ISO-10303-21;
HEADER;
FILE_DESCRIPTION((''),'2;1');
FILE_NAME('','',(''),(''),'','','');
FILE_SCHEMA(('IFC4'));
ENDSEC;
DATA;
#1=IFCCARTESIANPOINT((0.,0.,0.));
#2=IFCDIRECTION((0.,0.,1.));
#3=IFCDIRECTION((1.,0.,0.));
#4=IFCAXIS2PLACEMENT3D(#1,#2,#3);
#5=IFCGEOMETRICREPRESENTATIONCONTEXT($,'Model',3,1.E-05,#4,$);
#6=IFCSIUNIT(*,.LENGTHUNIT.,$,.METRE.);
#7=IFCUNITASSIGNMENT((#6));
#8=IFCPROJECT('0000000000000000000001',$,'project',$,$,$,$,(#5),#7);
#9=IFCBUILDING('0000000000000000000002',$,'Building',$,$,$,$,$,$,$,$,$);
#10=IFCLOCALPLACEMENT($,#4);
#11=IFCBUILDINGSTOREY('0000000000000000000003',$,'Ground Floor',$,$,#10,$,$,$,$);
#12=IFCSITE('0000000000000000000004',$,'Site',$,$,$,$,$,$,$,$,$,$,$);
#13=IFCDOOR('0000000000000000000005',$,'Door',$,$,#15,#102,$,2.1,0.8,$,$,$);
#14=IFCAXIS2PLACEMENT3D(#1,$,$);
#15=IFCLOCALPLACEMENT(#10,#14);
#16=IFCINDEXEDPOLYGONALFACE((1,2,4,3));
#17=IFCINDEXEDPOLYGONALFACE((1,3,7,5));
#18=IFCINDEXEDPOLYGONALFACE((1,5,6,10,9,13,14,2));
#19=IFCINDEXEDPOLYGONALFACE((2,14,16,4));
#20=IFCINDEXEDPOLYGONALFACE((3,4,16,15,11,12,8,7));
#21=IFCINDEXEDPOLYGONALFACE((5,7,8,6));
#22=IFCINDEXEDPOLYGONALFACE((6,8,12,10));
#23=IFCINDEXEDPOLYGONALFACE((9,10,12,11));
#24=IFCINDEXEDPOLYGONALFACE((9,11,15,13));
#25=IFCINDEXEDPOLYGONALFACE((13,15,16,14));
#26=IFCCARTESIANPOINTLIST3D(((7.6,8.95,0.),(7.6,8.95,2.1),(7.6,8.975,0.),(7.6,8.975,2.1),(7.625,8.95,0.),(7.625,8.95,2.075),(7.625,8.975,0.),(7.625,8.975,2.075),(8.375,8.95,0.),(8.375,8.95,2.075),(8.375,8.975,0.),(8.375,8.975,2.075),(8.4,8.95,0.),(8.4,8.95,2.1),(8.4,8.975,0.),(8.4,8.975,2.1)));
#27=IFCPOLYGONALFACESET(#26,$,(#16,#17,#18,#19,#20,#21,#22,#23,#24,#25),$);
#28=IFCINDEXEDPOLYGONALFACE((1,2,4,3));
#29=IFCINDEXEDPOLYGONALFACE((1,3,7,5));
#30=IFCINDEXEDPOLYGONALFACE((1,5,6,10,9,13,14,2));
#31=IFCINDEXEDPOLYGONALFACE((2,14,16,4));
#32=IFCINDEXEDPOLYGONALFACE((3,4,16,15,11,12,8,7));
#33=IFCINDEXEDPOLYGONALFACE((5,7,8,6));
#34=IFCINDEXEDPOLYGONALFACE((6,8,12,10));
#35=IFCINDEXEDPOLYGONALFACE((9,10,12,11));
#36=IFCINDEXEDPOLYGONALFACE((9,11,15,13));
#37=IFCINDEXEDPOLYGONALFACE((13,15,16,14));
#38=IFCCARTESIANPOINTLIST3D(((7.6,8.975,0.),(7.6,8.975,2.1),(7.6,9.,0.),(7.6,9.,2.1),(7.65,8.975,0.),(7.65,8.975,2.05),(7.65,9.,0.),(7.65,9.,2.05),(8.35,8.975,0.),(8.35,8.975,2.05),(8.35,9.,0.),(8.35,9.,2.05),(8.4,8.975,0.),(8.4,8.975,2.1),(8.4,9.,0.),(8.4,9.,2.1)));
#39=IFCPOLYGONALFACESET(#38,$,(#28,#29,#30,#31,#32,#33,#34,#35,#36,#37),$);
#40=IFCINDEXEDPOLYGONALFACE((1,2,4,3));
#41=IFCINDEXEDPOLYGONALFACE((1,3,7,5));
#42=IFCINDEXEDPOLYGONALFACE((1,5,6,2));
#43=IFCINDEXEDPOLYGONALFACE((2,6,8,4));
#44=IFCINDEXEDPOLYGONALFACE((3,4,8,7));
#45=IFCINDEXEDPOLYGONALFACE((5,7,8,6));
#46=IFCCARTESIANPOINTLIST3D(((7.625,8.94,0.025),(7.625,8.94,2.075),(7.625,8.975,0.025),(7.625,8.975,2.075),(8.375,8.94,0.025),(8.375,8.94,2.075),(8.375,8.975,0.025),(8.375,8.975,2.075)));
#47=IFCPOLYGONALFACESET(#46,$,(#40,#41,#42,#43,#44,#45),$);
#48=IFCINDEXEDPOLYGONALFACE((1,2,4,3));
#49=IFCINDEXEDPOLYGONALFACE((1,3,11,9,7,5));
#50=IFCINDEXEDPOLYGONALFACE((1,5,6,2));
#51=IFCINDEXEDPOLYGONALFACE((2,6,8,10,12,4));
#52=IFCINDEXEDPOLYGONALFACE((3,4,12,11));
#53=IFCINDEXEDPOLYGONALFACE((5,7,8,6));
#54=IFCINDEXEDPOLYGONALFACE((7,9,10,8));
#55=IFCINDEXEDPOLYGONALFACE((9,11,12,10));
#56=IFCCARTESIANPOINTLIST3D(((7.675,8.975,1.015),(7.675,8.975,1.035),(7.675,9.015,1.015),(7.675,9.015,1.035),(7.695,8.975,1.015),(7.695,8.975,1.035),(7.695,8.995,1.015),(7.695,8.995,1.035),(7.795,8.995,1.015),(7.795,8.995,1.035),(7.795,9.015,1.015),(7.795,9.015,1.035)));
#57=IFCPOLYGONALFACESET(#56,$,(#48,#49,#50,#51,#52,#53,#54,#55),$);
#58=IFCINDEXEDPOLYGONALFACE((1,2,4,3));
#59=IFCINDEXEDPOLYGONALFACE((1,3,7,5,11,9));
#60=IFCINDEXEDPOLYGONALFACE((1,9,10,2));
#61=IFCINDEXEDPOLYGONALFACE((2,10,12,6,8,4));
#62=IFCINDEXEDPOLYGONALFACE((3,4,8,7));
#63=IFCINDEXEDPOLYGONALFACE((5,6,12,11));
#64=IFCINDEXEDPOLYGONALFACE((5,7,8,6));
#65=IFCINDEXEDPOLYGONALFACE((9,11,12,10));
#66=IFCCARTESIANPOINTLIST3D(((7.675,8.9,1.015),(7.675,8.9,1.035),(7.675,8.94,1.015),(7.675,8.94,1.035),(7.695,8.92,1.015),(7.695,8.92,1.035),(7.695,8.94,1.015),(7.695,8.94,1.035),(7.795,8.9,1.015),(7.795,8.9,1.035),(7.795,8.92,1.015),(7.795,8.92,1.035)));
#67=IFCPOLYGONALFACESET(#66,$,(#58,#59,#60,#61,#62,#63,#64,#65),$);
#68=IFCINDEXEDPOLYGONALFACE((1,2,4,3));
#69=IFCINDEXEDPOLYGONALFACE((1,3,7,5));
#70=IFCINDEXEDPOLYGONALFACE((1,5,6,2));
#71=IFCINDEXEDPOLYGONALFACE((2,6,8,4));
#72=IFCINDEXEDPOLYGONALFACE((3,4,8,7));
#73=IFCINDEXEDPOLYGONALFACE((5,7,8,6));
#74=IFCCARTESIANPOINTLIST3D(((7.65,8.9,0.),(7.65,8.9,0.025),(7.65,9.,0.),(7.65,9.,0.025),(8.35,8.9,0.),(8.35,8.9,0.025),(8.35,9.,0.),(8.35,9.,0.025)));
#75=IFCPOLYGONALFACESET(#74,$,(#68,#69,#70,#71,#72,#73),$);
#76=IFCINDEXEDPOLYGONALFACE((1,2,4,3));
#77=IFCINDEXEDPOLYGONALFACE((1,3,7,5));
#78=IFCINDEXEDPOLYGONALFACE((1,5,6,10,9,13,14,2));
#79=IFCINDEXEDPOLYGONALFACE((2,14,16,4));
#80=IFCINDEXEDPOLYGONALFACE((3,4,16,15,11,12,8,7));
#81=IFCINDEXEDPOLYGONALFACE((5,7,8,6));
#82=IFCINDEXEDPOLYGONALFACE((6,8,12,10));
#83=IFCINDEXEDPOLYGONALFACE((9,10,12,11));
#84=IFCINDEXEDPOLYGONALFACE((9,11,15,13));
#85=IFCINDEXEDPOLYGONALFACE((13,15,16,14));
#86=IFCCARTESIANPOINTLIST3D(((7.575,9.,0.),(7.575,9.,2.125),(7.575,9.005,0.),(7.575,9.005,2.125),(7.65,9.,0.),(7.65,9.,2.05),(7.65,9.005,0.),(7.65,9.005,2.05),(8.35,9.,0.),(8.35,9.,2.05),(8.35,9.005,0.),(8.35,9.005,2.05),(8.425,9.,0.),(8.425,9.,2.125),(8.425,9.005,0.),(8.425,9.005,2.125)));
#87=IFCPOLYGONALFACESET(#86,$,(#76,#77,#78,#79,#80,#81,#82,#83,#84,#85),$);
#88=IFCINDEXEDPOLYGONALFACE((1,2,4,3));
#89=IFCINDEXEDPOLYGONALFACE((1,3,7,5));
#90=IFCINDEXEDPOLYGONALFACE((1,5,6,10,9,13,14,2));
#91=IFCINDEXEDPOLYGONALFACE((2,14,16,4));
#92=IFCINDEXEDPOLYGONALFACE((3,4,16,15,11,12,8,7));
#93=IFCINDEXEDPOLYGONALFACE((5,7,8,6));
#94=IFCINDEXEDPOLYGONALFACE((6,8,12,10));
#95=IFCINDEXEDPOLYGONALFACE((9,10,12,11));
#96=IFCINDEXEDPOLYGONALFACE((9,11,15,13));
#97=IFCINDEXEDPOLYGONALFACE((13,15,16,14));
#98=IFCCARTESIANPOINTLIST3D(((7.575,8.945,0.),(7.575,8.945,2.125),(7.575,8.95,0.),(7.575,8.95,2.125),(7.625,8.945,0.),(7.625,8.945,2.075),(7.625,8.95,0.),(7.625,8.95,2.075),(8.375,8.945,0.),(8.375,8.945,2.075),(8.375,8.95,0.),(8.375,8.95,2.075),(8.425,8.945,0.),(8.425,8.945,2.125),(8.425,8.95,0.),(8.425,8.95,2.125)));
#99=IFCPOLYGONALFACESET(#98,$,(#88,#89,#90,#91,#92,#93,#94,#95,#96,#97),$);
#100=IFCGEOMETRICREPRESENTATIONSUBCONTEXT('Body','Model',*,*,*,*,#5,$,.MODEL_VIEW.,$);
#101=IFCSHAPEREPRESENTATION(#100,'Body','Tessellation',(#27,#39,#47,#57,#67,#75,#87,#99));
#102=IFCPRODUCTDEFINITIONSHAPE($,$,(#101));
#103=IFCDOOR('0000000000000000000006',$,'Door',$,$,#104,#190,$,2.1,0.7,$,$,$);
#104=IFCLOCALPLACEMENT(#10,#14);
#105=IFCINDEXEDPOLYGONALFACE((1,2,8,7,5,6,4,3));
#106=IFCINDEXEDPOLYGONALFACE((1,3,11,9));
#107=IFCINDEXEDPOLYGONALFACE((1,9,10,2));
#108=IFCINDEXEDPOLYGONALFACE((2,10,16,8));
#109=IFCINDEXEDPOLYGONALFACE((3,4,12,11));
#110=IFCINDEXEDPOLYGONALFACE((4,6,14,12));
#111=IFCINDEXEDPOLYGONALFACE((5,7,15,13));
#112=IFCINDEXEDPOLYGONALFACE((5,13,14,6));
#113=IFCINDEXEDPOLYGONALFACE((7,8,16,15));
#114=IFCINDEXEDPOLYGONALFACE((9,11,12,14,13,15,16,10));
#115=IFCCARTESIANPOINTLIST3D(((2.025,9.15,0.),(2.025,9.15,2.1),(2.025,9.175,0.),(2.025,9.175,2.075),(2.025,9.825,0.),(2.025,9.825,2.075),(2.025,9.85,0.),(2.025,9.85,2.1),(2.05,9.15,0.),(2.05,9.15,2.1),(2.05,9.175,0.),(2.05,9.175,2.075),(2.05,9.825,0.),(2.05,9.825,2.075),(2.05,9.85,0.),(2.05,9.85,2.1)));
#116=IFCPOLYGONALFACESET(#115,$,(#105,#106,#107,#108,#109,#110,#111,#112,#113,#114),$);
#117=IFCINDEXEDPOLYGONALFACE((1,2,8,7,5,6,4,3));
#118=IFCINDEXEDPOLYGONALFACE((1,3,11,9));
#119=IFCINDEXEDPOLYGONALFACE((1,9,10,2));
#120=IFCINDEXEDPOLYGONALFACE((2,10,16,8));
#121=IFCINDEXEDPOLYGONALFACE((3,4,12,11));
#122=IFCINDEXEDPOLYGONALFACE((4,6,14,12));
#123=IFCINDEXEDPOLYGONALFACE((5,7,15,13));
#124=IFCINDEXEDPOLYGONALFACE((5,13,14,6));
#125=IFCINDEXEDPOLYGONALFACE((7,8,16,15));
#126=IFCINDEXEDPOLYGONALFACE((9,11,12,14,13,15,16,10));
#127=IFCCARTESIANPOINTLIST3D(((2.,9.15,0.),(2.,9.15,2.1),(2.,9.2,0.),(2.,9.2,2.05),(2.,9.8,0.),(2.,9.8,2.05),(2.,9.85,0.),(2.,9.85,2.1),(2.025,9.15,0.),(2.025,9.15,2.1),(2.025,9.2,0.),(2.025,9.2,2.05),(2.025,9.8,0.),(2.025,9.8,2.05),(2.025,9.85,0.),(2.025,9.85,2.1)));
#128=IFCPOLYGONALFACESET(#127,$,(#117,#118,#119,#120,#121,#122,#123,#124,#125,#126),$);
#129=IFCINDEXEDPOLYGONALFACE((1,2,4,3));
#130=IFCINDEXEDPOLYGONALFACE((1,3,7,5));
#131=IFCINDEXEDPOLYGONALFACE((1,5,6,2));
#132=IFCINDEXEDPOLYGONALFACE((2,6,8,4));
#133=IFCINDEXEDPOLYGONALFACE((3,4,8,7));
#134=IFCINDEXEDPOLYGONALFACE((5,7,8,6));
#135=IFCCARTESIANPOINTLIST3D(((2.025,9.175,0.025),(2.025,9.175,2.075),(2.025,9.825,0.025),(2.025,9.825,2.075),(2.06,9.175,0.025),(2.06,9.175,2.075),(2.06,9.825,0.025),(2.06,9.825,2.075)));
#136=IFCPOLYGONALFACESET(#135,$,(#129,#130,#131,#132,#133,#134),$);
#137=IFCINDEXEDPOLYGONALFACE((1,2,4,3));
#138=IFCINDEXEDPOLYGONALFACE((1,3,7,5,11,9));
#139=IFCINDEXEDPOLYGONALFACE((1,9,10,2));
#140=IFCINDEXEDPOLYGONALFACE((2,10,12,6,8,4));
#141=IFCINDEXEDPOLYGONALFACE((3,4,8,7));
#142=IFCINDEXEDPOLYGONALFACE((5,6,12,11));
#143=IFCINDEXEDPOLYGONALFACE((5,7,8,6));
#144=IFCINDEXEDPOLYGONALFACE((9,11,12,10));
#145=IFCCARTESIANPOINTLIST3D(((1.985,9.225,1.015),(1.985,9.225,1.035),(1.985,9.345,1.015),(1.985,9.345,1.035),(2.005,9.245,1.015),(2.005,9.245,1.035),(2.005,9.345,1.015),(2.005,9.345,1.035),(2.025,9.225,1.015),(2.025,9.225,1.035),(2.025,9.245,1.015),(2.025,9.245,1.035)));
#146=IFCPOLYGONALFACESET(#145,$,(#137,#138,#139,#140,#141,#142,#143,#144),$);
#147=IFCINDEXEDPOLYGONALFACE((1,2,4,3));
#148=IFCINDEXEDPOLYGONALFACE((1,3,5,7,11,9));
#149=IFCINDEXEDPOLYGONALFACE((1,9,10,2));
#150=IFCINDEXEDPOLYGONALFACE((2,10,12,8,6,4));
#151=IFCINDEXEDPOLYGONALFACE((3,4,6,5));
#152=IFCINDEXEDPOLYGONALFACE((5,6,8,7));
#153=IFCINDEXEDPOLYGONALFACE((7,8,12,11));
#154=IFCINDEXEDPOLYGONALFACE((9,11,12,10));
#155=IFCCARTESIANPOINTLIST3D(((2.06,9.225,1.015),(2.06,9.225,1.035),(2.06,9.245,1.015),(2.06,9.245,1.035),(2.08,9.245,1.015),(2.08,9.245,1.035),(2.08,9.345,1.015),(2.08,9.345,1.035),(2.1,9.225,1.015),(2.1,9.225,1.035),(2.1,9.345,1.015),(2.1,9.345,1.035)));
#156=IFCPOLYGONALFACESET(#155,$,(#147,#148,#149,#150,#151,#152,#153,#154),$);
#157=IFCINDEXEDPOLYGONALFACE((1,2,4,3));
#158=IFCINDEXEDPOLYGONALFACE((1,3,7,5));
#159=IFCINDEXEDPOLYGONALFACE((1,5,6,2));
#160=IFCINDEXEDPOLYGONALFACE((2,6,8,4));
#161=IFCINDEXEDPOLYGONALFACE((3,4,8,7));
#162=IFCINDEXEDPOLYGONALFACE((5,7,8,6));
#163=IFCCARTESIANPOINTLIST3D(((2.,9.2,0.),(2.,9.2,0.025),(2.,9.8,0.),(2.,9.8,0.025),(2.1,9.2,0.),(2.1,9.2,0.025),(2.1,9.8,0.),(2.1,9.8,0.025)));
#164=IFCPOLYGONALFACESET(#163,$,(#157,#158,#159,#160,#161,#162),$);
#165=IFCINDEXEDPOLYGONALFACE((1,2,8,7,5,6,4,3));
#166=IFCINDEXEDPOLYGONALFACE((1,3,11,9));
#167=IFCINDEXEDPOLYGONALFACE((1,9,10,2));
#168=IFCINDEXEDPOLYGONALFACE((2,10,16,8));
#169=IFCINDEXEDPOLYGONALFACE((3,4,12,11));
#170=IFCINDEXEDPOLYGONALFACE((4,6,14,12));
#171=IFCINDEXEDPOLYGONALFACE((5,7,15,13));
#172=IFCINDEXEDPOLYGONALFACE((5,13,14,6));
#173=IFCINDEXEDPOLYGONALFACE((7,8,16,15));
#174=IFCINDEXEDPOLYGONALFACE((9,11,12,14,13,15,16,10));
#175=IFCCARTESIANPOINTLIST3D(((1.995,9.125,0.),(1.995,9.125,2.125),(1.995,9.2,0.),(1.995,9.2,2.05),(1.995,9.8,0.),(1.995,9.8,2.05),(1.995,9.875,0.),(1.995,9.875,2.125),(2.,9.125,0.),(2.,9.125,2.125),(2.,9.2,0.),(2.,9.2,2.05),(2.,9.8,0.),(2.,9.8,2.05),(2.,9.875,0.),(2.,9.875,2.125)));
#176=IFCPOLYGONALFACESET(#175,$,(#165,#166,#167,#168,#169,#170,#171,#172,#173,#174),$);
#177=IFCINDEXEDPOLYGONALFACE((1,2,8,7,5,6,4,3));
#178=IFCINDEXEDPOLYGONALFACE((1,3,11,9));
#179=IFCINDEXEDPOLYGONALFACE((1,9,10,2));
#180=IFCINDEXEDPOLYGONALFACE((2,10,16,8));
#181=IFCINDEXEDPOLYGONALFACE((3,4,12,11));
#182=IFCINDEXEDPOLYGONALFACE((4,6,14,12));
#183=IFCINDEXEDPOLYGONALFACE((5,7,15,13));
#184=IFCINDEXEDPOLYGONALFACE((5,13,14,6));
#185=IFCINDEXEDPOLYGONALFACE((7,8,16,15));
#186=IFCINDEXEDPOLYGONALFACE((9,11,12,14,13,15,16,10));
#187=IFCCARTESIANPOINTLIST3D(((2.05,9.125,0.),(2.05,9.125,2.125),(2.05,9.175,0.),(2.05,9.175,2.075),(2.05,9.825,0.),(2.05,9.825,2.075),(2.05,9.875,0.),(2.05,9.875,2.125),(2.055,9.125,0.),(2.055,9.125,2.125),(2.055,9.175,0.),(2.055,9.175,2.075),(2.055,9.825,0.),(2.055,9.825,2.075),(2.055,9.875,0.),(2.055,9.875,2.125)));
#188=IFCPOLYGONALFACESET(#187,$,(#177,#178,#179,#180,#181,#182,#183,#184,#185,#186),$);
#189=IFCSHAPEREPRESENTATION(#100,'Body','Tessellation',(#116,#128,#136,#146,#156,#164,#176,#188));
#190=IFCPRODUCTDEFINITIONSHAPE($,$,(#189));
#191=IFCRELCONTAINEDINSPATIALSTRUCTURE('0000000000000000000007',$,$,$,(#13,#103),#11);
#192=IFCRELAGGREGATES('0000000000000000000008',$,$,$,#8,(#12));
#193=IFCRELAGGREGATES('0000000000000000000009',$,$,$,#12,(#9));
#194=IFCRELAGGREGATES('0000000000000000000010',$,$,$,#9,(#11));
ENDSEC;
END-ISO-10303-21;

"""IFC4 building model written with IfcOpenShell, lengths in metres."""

from ifc_helpers import new_model, si_unit, frame, origin_with_axes, place, context, subcontext, project, spatial, line, indexed_curve, outline, extrude, element, save


model = new_model("IFC4")

# Units and contexts
model_context = context("Model", 3, precision=1e-05, world=origin_with_axes())
body_context = subcontext(model_context, "Body", "Model", "MODEL_VIEW")
ifc_project = project(units=[si_unit("LENGTHUNIT", "METRE")], contexts=[model_context])

# Site, building, storey
site = spatial("IfcSite", under=ifc_project, Name="Site")
building = spatial("IfcBuilding", under=site, Name="Building")
storey_placement = place(None, origin_with_axes())
storey = spatial("IfcBuildingStorey", under=building, at=storey_placement, Name="Ground Floor")

# Doors
door_1_placement = place(storey_placement, frame((8.4, 9.0, 0.0), z_axis=(0.0, 0.0, 1.0), x_axis=(-1.0, 0.0, 0.0)))
element("IfcDoor", 1, at=door_1_placement, inside=storey, Name="Door", OverallHeight=2.1, OverallWidth=0.8, context=body_context, shape_type="SweptSolid", body=[
    extrude(outline(indexed_curve([(0.0, 0.0), (0.0, 2.1), (0.8, 2.1), (0.8, 0.0), (0.775, 0.0), (0.775, 2.075), (0.025, 2.075), (0.025, 0.0)], segments=[line(1, 2, 3, 4, 5, 6, 7, 8, 1)])), frame((0.0, 0.025, 0.0), z_axis=(0.0, -1.0, 0.0), x_axis=(1.0, 0.0, 0.0)), (0.0, 0.0, -1.0), 0.025),
    extrude(outline(indexed_curve([(0.0, 0.0), (0.0, 2.1), (0.8, 2.1), (0.8, 0.0), (0.75, 0.0), (0.75, 2.05), (0.05, 2.05), (0.05, 0.0)], segments=[line(1, 2, 3, 4, 5, 6, 7, 8, 1)])), frame((0.0, 0.0, 0.0), z_axis=(0.0, -1.0, 0.0), x_axis=(1.0, 0.0, 0.0)), (0.0, 0.0, -1.0), 0.025),
    extrude(outline(indexed_curve([(0.0, 0.0), (0.75, 0.0), (0.75, 0.035), (0.0, 0.035)], segments=[line(1, 2, 3, 4, 1)])), frame((0.025, 0.025, 0.025), z_axis=(0.0, 0.0, 1.0), x_axis=(1.0, 0.0, 0.0)), (0.0, 0.0, 1.0), 2.05),
    extrude(outline(indexed_curve([(0.0, 0.0), (0.0, -0.04), (-0.12, -0.04), (-0.12, -0.02), (-0.02, -0.02), (-0.02, 0.0)], segments=[line(1, 2, 3, 4, 5, 6, 1)])), frame((0.725, 0.025, 1.015), z_axis=(0.0, 0.0, 1.0), x_axis=(1.0, 0.0, 0.0)), (0.0, 0.0, 1.0), 0.02),
    extrude(outline(indexed_curve([(0.0, 0.0), (0.0, 0.04), (-0.12, 0.04), (-0.12, 0.02), (-0.02, 0.02), (-0.02, 0.0)], segments=[line(1, 2, 3, 4, 5, 6, 1)])), frame((0.725, 0.06, 1.015), z_axis=(0.0, 0.0, 1.0), x_axis=(1.0, 0.0, 0.0)), (0.0, 0.0, 1.0), 0.02),
    extrude(outline(indexed_curve([(0.0, 0.0), (0.7, 0.0), (0.7, 0.1), (0.0, 0.1)], segments=[line(1, 2, 3, 4, 1)])), frame((0.05, 0.0, 0.0), z_axis=(0.0, 0.0, 1.0), x_axis=(1.0, 0.0, 0.0)), (0.0, 0.0, 1.0), 0.025),
    extrude(outline(indexed_curve([(0.0, 0.0), (0.0, 2.125), (0.85, 2.125), (0.85, 0.0), (0.775, 0.0), (0.775, 2.05), (0.075, 2.05), (0.075, 0.0)], segments=[line(1, 2, 3, 4, 5, 6, 7, 8, 1)])), frame((-0.025, -0.005, 0.0), z_axis=(0.0, -1.0, 0.0), x_axis=(1.0, 0.0, 0.0)), (0.0, 0.0, -1.0), 0.005),
    extrude(outline(indexed_curve([(0.0, 0.0), (0.0, 2.125), (0.85, 2.125), (0.85, 0.0), (0.8, 0.0), (0.8, 2.075), (0.05, 2.075), (0.05, 0.0)], segments=[line(1, 2, 3, 4, 5, 6, 7, 8, 1)])), frame((-0.025, 0.05, 0.0), z_axis=(0.0, -1.0, 0.0), x_axis=(1.0, 0.0, 0.0)), (0.0, 0.0, -1.0), 0.005),
])
door_2_placement = place(storey_placement, frame((2.0, 9.85, 0.0), z_axis=(0.0, 0.0, 1.0), x_axis=(0.0, -1.0, 0.0)))
element("IfcDoor", 2, at=door_2_placement, inside=storey, Name="Door", OverallHeight=2.1, OverallWidth=0.7, context=body_context, shape_type="SweptSolid", body=[
    extrude(outline(indexed_curve([(0.0, 0.0), (0.0, 2.1), (0.7, 2.1), (0.7, 0.0), (0.675, 0.0), (0.675, 2.075), (0.025, 2.075), (0.025, 0.0)], segments=[line(1, 2, 3, 4, 5, 6, 7, 8, 1)])), frame((0.0, 0.025, 0.0), z_axis=(0.0, -1.0, 0.0), x_axis=(1.0, 0.0, 0.0)), (0.0, 0.0, -1.0), 0.025),
    extrude(outline(indexed_curve([(0.0, 0.0), (0.0, 2.1), (0.7, 2.1), (0.7, 0.0), (0.65, 0.0), (0.65, 2.05), (0.05, 2.05), (0.05, 0.0)], segments=[line(1, 2, 3, 4, 5, 6, 7, 8, 1)])), frame((0.0, 0.0, 0.0), z_axis=(0.0, -1.0, 0.0), x_axis=(1.0, 0.0, 0.0)), (0.0, 0.0, -1.0), 0.025),
    extrude(outline(indexed_curve([(0.0, 0.0), (0.65, 0.0), (0.65, 0.035), (0.0, 0.035)], segments=[line(1, 2, 3, 4, 1)])), frame((0.025, 0.025, 0.025), z_axis=(0.0, 0.0, 1.0), x_axis=(1.0, 0.0, 0.0)), (0.0, 0.0, 1.0), 2.05),
    extrude(outline(indexed_curve([(0.0, 0.0), (0.0, -0.04), (-0.12, -0.04), (-0.12, -0.02), (-0.02, -0.02), (-0.02, 0.0)], segments=[line(1, 2, 3, 4, 5, 6, 1)])), frame((0.625, 0.025, 1.015), z_axis=(0.0, 0.0, 1.0), x_axis=(1.0, 0.0, 0.0)), (0.0, 0.0, 1.0), 0.02),
    extrude(outline(indexed_curve([(0.0, 0.0), (0.0, 0.04), (-0.12, 0.04), (-0.12, 0.02), (-0.02, 0.02), (-0.02, 0.0)], segments=[line(1, 2, 3, 4, 5, 6, 1)])), frame((0.625, 0.06, 1.015), z_axis=(0.0, 0.0, 1.0), x_axis=(1.0, 0.0, 0.0)), (0.0, 0.0, 1.0), 0.02),
    extrude(outline(indexed_curve([(0.0, 0.0), (0.6, 0.0), (0.6, 0.1), (0.0, 0.1)], segments=[line(1, 2, 3, 4, 1)])), frame((0.05, 0.0, 0.0), z_axis=(0.0, 0.0, 1.0), x_axis=(1.0, 0.0, 0.0)), (0.0, 0.0, 1.0), 0.025),
    extrude(outline(indexed_curve([(0.0, 0.0), (0.0, 2.125), (0.75, 2.125), (0.75, 0.0), (0.675, 0.0), (0.675, 2.05), (0.075, 2.05), (0.075, 0.0)], segments=[line(1, 2, 3, 4, 5, 6, 7, 8, 1)])), frame((-0.025, -0.005, 0.0), z_axis=(0.0, -1.0, 0.0), x_axis=(1.0, 0.0, 0.0)), (0.0, 0.0, -1.0), 0.005),
    extrude(outline(indexed_curve([(0.0, 0.0), (0.0, 2.125), (0.75, 2.125), (0.75, 0.0), (0.7, 0.0), (0.7, 2.075), (0.05, 2.075), (0.05, 0.0)], segments=[line(1, 2, 3, 4, 5, 6, 7, 8, 1)])), frame((-0.025, 0.05, 0.0), z_axis=(0.0, -1.0, 0.0), x_axis=(1.0, 0.0, 0.0)), (0.0, 0.0, -1.0), 0.005),
])

save(model, "model.ifc")
